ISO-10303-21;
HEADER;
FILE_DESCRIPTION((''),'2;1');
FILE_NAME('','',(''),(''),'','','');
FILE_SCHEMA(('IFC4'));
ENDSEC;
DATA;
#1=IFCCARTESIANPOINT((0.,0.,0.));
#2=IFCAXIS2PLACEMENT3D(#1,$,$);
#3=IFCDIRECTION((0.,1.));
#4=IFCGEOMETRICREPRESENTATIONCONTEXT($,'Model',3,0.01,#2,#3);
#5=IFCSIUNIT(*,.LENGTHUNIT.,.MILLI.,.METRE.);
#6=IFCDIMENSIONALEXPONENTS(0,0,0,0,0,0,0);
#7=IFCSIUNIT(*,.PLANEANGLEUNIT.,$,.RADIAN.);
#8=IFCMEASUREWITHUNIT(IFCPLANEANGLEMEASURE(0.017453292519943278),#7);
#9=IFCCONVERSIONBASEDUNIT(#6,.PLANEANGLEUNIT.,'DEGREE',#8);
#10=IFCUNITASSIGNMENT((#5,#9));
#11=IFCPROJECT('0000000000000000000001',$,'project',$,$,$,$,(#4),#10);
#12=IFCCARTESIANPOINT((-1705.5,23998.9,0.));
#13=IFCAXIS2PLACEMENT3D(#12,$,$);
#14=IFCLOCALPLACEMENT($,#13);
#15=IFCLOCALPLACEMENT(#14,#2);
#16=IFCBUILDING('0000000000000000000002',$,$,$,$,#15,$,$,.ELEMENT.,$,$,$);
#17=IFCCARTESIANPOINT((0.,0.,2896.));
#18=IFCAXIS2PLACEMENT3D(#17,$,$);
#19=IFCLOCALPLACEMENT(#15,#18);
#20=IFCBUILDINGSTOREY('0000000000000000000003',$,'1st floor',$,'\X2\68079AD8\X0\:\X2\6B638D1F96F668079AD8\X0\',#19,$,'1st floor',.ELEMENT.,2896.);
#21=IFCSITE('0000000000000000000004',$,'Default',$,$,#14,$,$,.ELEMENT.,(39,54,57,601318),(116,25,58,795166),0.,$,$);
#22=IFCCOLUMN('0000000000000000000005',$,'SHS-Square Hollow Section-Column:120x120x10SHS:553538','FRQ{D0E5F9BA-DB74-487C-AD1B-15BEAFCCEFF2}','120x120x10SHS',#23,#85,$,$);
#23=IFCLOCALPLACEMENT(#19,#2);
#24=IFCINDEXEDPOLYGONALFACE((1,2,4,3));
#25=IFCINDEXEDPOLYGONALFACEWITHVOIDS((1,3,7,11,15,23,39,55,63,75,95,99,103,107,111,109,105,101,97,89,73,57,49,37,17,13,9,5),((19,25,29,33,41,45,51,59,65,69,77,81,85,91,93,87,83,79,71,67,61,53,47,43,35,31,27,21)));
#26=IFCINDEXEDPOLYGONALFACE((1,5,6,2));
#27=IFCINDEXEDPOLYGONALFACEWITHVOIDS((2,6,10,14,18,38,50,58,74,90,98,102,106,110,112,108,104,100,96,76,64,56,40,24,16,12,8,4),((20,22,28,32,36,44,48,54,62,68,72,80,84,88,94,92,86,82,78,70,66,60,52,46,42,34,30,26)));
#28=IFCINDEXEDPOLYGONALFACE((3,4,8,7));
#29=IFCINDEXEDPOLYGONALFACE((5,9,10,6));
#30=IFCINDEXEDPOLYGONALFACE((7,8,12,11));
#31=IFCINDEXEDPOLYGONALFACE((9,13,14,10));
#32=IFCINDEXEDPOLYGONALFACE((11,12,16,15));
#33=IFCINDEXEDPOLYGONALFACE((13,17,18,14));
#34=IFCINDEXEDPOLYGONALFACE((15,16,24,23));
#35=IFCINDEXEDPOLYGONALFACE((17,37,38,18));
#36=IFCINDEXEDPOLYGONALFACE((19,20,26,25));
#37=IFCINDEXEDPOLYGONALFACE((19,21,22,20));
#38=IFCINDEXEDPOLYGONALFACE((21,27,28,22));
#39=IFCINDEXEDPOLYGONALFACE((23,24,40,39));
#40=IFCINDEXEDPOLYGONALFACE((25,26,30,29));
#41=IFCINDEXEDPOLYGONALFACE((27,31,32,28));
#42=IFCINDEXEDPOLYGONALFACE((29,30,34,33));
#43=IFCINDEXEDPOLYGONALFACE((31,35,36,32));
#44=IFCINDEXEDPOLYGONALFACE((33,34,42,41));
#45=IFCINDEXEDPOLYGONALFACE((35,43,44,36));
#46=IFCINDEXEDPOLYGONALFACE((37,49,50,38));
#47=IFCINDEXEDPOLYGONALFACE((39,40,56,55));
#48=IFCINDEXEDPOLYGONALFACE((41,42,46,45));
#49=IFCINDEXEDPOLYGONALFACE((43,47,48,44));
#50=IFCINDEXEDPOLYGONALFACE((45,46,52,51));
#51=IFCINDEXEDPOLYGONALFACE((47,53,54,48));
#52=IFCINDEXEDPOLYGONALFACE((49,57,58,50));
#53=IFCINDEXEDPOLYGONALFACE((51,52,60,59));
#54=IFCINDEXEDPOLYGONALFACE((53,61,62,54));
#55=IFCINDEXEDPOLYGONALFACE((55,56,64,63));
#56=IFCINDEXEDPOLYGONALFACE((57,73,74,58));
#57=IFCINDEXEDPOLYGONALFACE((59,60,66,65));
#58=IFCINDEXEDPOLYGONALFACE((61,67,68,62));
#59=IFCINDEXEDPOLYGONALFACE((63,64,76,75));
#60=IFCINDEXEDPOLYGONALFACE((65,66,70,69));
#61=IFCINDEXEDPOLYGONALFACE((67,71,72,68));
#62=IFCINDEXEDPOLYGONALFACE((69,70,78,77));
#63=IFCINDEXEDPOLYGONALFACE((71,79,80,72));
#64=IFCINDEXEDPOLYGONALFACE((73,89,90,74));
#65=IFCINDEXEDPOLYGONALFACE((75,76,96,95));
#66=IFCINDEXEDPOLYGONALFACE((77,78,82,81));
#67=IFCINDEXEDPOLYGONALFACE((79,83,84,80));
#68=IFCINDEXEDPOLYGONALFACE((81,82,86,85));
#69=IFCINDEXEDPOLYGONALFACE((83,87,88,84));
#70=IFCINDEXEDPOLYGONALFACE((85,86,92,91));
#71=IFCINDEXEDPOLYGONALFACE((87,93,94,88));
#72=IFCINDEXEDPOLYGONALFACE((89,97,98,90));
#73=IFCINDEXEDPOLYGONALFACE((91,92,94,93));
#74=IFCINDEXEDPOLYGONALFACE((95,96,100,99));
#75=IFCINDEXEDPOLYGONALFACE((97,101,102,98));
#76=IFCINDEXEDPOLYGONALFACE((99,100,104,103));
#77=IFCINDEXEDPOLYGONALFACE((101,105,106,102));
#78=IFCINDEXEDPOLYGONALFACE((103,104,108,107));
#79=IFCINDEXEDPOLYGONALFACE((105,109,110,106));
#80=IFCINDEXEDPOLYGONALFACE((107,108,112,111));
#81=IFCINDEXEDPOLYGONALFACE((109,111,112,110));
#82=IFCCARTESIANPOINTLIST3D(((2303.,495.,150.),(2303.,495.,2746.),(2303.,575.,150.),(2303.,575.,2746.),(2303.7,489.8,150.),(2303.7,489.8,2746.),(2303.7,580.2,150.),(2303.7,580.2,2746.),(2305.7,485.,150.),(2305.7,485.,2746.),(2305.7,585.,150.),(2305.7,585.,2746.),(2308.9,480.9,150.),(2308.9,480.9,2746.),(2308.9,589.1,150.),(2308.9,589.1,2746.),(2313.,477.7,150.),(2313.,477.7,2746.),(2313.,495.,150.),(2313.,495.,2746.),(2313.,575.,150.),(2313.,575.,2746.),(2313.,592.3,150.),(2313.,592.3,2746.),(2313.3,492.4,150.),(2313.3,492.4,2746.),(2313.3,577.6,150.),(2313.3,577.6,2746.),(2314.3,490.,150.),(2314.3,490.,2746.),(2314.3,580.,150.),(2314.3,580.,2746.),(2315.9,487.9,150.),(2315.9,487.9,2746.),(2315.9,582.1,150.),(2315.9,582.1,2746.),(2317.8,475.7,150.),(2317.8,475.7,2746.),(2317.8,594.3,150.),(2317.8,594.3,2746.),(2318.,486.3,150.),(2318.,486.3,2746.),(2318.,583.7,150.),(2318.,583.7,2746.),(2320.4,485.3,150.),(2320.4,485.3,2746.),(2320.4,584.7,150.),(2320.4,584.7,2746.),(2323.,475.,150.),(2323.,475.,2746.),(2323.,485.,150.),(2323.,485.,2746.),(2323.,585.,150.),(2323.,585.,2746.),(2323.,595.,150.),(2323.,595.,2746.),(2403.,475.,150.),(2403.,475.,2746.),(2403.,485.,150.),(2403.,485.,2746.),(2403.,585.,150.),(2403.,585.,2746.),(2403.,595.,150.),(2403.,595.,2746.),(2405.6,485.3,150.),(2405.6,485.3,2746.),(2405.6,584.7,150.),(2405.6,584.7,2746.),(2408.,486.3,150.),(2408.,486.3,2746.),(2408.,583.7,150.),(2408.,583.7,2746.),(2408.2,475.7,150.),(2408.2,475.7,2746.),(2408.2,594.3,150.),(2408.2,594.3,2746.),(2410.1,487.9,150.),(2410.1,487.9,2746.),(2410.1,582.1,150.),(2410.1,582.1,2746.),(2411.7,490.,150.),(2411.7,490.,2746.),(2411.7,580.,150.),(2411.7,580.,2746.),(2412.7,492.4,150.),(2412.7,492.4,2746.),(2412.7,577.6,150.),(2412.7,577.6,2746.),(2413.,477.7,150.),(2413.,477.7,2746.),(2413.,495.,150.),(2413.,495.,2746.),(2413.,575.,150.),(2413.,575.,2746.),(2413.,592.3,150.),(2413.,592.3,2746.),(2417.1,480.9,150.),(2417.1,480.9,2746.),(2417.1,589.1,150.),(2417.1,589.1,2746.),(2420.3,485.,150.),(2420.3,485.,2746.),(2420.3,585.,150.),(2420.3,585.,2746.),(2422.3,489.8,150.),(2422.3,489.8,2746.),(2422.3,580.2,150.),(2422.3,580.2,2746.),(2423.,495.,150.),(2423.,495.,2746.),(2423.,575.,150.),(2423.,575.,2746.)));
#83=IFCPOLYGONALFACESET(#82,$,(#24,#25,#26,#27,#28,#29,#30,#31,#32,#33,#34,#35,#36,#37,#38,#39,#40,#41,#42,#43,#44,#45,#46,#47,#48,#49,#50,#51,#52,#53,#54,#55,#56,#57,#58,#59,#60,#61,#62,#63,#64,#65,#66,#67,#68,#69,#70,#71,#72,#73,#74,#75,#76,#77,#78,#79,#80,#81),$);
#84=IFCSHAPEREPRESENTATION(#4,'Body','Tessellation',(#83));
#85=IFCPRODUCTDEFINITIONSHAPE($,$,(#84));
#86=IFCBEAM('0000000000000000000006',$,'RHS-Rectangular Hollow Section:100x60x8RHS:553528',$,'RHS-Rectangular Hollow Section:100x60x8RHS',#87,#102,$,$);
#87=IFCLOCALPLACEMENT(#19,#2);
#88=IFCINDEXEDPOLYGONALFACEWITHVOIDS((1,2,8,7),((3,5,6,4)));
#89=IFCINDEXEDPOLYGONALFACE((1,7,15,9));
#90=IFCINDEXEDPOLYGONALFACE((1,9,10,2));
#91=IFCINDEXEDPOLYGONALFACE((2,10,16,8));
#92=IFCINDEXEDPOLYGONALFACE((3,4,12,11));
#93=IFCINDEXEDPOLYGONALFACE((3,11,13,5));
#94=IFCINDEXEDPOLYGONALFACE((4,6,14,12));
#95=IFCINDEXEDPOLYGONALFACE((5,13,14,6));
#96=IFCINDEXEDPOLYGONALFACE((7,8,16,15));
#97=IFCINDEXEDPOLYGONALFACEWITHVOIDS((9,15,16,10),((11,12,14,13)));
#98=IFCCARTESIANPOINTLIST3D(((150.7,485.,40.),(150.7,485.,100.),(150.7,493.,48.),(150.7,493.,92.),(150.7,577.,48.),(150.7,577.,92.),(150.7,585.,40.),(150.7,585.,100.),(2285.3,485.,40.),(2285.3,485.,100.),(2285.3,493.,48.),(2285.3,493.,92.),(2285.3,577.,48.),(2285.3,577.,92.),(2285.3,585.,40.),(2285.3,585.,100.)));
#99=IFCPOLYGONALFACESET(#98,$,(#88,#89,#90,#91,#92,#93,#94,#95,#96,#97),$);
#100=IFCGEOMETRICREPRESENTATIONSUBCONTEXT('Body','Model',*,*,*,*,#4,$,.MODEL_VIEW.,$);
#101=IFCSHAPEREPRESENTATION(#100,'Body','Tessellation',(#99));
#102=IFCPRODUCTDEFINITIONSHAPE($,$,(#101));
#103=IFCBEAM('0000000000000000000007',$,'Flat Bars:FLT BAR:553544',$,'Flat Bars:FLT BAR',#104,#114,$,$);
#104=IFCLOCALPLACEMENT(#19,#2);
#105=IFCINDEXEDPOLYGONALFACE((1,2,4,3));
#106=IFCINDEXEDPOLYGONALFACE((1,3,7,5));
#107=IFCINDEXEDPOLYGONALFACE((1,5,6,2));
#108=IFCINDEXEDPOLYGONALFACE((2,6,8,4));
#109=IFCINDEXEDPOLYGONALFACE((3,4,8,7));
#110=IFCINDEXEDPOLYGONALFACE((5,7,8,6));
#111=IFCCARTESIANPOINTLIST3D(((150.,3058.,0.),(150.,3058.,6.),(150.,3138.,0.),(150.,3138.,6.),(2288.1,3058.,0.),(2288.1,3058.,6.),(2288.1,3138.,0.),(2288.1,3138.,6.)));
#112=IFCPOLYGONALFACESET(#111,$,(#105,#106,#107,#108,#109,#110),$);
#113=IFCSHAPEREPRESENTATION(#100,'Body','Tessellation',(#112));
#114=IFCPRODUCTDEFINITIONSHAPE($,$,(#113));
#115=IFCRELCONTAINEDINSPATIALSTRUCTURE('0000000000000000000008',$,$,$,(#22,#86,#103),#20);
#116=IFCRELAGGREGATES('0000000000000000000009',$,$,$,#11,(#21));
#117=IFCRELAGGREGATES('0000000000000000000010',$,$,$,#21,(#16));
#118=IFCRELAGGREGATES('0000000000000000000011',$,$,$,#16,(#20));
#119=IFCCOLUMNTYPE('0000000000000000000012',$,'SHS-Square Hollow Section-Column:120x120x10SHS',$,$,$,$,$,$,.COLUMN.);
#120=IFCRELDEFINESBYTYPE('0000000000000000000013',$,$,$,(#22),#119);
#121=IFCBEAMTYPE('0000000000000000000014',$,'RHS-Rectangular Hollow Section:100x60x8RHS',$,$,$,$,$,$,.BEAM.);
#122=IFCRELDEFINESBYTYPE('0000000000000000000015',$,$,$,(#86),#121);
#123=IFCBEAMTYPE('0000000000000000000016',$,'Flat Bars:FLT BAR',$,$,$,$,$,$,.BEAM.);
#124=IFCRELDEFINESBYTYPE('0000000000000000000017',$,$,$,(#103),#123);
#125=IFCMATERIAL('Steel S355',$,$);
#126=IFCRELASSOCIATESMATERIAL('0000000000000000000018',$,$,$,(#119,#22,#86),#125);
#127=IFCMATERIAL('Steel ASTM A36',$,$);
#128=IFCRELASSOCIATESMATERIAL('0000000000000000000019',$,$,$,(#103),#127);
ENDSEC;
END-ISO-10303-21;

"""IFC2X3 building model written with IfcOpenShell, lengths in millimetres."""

from ifc_helpers import new_model, entity, si_unit, converted_unit, direction, frame, frame_2d, origin, origin_2d, origin_2d_with_axis, place, context, subcontext, project, spatial, rectangle, hollow_rectangle, extrude, boolean, clip, halfspace, material, type_object, element, save


model = new_model("IFC2X3")

# Units and contexts
model_context = context("Model", 3, precision=0.01, world=origin(), true_north=direction((0.0, 1.0)))
body_context = subcontext(model_context, "Body", "Model", "MODEL_VIEW")
ifc_project = project(units=[si_unit("LENGTHUNIT", "METRE", prefix="MILLI"), converted_unit("PLANEANGLEUNIT", "DEGREE", entity("IfcPlaneAngleMeasure", 0.017453292519943278), si_unit("PLANEANGLEUNIT", "RADIAN"), dimensions=[0, 0, 0, 0, 0, 0, 0])], contexts=[model_context])

# Site, building, storey
site_placement = place(None, frame((-1705.5, 23998.9, 0.0)))
site = spatial("IfcSite", under=ifc_project, at=site_placement, Name="Default", CompositionType="ELEMENT", RefLatitude=(39, 54, 57, 601318), RefLongitude=(116, 25, 58, 795166), RefElevation=0.0)
building_placement = place(site_placement, origin())
building = spatial("IfcBuilding", under=site, at=building_placement, CompositionType="ELEMENT")
storey_placement = place(building_placement, frame((0.0, 0.0, 2896.0)))
storey = spatial("IfcBuildingStorey", under=building, at=storey_placement, Name="1st floor", ObjectType="标高:正负零标高", LongName="1st floor", CompositionType="ELEMENT", Elevation=2896.0)

# Shared definitions
ifc_material_1 = material(Name="Steel S355")

# Column
column_type_1 = type_object("IfcColumnType", Name="SHS-Square Hollow Section-Column:120x120x10SHS", PredefinedType="COLUMN", material=ifc_material_1)
column_1_placement = place(storey_placement, frame((2363.0, 535.0, 2746.0), z_axis=(0.0, 0.0, 1.0), x_axis=(0.0, -1.0, 0.0)))
element("IfcColumn", 1, at=column_1_placement, inside=storey, type_object=column_type_1, material=ifc_material_1, Name="SHS-Square Hollow Section-Column:120x120x10SHS:553538", Description="FRQ{D0E5F9BA-DB74-487C-AD1B-15BEAFCCEFF2}", ObjectType="120x120x10SHS", context=model_context, shape_type="Clipping", body=[
    clip(extrude(hollow_rectangle(XDim=120.0, YDim=120.0, WallThickness=10.0, InnerFilletRadius=10.0, OuterFilletRadius=20.0, at=origin_2d()), origin(), (0.0, 0.0, -1.0), 2680.9), halfspace(frame((535.0, -2363.0, -2596.0), z_axis=(0.0, 0.0, 1.0), x_axis=(0.0, 1.0, 0.0)), True)),
])

# Beams
beam_type_1 = type_object("IfcBeamType", Name="RHS-Rectangular Hollow Section:100x60x8RHS", PredefinedType="BEAM")
beam_1_placement = place(storey_placement, frame((150.7, 585.0, 70.0)))
element("IfcBeam", 2, at=beam_1_placement, inside=storey, type_object=beam_type_1, material=ifc_material_1, Name="RHS-Rectangular Hollow Section:100x60x8RHS:553528", ObjectType="RHS-Rectangular Hollow Section:100x60x8RHS", context=body_context, shape_type="SweptSolid", body=[
    boolean("DIFFERENCE", extrude(rectangle(XDim=60.0, YDim=100.0, at=frame_2d((0.0, 0.0), x_axis=(1.0, 0.0))), frame((0.0, -50.0, 0.0), z_axis=(1.0, 0.0, 0.0), x_axis=(0.0, 0.0, -1.0)), (0.0, 0.0, 1.0), 2134.6), extrude(rectangle(XDim=44.0, YDim=84.0, at=frame_2d((0.0, 0.0), x_axis=(0.0, 1.0))), frame((2134.6, -50.0, 0.0), z_axis=(-1.0, 0.0, 0.0), x_axis=(0.0, 1.0, 0.0)), (0.0, 0.0, 1.0), 2134.6)),
])
ifc_material_2 = material(Name="Steel ASTM A36")
beam_type_2 = type_object("IfcBeamType", Name="Flat Bars:FLT BAR", PredefinedType="BEAM")
beam_2_placement = place(storey_placement, frame((150.0, 3098.0, 6.0)))
element("IfcBeam", 3, at=beam_2_placement, inside=storey, type_object=beam_type_2, material=ifc_material_2, Name="Flat Bars:FLT BAR:553544", ObjectType="Flat Bars:FLT BAR", context=body_context, shape_type="SweptSolid", body=[
    extrude(rectangle(XDim=6.0, YDim=80.0, at=origin_2d_with_axis()), frame((0.0, 0.0, -3.0), z_axis=(1.0, 0.0, 0.0), x_axis=(0.0, 0.0, -1.0)), (0.0, 0.0, 1.0), 2138.1),
])

save(model, "model.ifc")
